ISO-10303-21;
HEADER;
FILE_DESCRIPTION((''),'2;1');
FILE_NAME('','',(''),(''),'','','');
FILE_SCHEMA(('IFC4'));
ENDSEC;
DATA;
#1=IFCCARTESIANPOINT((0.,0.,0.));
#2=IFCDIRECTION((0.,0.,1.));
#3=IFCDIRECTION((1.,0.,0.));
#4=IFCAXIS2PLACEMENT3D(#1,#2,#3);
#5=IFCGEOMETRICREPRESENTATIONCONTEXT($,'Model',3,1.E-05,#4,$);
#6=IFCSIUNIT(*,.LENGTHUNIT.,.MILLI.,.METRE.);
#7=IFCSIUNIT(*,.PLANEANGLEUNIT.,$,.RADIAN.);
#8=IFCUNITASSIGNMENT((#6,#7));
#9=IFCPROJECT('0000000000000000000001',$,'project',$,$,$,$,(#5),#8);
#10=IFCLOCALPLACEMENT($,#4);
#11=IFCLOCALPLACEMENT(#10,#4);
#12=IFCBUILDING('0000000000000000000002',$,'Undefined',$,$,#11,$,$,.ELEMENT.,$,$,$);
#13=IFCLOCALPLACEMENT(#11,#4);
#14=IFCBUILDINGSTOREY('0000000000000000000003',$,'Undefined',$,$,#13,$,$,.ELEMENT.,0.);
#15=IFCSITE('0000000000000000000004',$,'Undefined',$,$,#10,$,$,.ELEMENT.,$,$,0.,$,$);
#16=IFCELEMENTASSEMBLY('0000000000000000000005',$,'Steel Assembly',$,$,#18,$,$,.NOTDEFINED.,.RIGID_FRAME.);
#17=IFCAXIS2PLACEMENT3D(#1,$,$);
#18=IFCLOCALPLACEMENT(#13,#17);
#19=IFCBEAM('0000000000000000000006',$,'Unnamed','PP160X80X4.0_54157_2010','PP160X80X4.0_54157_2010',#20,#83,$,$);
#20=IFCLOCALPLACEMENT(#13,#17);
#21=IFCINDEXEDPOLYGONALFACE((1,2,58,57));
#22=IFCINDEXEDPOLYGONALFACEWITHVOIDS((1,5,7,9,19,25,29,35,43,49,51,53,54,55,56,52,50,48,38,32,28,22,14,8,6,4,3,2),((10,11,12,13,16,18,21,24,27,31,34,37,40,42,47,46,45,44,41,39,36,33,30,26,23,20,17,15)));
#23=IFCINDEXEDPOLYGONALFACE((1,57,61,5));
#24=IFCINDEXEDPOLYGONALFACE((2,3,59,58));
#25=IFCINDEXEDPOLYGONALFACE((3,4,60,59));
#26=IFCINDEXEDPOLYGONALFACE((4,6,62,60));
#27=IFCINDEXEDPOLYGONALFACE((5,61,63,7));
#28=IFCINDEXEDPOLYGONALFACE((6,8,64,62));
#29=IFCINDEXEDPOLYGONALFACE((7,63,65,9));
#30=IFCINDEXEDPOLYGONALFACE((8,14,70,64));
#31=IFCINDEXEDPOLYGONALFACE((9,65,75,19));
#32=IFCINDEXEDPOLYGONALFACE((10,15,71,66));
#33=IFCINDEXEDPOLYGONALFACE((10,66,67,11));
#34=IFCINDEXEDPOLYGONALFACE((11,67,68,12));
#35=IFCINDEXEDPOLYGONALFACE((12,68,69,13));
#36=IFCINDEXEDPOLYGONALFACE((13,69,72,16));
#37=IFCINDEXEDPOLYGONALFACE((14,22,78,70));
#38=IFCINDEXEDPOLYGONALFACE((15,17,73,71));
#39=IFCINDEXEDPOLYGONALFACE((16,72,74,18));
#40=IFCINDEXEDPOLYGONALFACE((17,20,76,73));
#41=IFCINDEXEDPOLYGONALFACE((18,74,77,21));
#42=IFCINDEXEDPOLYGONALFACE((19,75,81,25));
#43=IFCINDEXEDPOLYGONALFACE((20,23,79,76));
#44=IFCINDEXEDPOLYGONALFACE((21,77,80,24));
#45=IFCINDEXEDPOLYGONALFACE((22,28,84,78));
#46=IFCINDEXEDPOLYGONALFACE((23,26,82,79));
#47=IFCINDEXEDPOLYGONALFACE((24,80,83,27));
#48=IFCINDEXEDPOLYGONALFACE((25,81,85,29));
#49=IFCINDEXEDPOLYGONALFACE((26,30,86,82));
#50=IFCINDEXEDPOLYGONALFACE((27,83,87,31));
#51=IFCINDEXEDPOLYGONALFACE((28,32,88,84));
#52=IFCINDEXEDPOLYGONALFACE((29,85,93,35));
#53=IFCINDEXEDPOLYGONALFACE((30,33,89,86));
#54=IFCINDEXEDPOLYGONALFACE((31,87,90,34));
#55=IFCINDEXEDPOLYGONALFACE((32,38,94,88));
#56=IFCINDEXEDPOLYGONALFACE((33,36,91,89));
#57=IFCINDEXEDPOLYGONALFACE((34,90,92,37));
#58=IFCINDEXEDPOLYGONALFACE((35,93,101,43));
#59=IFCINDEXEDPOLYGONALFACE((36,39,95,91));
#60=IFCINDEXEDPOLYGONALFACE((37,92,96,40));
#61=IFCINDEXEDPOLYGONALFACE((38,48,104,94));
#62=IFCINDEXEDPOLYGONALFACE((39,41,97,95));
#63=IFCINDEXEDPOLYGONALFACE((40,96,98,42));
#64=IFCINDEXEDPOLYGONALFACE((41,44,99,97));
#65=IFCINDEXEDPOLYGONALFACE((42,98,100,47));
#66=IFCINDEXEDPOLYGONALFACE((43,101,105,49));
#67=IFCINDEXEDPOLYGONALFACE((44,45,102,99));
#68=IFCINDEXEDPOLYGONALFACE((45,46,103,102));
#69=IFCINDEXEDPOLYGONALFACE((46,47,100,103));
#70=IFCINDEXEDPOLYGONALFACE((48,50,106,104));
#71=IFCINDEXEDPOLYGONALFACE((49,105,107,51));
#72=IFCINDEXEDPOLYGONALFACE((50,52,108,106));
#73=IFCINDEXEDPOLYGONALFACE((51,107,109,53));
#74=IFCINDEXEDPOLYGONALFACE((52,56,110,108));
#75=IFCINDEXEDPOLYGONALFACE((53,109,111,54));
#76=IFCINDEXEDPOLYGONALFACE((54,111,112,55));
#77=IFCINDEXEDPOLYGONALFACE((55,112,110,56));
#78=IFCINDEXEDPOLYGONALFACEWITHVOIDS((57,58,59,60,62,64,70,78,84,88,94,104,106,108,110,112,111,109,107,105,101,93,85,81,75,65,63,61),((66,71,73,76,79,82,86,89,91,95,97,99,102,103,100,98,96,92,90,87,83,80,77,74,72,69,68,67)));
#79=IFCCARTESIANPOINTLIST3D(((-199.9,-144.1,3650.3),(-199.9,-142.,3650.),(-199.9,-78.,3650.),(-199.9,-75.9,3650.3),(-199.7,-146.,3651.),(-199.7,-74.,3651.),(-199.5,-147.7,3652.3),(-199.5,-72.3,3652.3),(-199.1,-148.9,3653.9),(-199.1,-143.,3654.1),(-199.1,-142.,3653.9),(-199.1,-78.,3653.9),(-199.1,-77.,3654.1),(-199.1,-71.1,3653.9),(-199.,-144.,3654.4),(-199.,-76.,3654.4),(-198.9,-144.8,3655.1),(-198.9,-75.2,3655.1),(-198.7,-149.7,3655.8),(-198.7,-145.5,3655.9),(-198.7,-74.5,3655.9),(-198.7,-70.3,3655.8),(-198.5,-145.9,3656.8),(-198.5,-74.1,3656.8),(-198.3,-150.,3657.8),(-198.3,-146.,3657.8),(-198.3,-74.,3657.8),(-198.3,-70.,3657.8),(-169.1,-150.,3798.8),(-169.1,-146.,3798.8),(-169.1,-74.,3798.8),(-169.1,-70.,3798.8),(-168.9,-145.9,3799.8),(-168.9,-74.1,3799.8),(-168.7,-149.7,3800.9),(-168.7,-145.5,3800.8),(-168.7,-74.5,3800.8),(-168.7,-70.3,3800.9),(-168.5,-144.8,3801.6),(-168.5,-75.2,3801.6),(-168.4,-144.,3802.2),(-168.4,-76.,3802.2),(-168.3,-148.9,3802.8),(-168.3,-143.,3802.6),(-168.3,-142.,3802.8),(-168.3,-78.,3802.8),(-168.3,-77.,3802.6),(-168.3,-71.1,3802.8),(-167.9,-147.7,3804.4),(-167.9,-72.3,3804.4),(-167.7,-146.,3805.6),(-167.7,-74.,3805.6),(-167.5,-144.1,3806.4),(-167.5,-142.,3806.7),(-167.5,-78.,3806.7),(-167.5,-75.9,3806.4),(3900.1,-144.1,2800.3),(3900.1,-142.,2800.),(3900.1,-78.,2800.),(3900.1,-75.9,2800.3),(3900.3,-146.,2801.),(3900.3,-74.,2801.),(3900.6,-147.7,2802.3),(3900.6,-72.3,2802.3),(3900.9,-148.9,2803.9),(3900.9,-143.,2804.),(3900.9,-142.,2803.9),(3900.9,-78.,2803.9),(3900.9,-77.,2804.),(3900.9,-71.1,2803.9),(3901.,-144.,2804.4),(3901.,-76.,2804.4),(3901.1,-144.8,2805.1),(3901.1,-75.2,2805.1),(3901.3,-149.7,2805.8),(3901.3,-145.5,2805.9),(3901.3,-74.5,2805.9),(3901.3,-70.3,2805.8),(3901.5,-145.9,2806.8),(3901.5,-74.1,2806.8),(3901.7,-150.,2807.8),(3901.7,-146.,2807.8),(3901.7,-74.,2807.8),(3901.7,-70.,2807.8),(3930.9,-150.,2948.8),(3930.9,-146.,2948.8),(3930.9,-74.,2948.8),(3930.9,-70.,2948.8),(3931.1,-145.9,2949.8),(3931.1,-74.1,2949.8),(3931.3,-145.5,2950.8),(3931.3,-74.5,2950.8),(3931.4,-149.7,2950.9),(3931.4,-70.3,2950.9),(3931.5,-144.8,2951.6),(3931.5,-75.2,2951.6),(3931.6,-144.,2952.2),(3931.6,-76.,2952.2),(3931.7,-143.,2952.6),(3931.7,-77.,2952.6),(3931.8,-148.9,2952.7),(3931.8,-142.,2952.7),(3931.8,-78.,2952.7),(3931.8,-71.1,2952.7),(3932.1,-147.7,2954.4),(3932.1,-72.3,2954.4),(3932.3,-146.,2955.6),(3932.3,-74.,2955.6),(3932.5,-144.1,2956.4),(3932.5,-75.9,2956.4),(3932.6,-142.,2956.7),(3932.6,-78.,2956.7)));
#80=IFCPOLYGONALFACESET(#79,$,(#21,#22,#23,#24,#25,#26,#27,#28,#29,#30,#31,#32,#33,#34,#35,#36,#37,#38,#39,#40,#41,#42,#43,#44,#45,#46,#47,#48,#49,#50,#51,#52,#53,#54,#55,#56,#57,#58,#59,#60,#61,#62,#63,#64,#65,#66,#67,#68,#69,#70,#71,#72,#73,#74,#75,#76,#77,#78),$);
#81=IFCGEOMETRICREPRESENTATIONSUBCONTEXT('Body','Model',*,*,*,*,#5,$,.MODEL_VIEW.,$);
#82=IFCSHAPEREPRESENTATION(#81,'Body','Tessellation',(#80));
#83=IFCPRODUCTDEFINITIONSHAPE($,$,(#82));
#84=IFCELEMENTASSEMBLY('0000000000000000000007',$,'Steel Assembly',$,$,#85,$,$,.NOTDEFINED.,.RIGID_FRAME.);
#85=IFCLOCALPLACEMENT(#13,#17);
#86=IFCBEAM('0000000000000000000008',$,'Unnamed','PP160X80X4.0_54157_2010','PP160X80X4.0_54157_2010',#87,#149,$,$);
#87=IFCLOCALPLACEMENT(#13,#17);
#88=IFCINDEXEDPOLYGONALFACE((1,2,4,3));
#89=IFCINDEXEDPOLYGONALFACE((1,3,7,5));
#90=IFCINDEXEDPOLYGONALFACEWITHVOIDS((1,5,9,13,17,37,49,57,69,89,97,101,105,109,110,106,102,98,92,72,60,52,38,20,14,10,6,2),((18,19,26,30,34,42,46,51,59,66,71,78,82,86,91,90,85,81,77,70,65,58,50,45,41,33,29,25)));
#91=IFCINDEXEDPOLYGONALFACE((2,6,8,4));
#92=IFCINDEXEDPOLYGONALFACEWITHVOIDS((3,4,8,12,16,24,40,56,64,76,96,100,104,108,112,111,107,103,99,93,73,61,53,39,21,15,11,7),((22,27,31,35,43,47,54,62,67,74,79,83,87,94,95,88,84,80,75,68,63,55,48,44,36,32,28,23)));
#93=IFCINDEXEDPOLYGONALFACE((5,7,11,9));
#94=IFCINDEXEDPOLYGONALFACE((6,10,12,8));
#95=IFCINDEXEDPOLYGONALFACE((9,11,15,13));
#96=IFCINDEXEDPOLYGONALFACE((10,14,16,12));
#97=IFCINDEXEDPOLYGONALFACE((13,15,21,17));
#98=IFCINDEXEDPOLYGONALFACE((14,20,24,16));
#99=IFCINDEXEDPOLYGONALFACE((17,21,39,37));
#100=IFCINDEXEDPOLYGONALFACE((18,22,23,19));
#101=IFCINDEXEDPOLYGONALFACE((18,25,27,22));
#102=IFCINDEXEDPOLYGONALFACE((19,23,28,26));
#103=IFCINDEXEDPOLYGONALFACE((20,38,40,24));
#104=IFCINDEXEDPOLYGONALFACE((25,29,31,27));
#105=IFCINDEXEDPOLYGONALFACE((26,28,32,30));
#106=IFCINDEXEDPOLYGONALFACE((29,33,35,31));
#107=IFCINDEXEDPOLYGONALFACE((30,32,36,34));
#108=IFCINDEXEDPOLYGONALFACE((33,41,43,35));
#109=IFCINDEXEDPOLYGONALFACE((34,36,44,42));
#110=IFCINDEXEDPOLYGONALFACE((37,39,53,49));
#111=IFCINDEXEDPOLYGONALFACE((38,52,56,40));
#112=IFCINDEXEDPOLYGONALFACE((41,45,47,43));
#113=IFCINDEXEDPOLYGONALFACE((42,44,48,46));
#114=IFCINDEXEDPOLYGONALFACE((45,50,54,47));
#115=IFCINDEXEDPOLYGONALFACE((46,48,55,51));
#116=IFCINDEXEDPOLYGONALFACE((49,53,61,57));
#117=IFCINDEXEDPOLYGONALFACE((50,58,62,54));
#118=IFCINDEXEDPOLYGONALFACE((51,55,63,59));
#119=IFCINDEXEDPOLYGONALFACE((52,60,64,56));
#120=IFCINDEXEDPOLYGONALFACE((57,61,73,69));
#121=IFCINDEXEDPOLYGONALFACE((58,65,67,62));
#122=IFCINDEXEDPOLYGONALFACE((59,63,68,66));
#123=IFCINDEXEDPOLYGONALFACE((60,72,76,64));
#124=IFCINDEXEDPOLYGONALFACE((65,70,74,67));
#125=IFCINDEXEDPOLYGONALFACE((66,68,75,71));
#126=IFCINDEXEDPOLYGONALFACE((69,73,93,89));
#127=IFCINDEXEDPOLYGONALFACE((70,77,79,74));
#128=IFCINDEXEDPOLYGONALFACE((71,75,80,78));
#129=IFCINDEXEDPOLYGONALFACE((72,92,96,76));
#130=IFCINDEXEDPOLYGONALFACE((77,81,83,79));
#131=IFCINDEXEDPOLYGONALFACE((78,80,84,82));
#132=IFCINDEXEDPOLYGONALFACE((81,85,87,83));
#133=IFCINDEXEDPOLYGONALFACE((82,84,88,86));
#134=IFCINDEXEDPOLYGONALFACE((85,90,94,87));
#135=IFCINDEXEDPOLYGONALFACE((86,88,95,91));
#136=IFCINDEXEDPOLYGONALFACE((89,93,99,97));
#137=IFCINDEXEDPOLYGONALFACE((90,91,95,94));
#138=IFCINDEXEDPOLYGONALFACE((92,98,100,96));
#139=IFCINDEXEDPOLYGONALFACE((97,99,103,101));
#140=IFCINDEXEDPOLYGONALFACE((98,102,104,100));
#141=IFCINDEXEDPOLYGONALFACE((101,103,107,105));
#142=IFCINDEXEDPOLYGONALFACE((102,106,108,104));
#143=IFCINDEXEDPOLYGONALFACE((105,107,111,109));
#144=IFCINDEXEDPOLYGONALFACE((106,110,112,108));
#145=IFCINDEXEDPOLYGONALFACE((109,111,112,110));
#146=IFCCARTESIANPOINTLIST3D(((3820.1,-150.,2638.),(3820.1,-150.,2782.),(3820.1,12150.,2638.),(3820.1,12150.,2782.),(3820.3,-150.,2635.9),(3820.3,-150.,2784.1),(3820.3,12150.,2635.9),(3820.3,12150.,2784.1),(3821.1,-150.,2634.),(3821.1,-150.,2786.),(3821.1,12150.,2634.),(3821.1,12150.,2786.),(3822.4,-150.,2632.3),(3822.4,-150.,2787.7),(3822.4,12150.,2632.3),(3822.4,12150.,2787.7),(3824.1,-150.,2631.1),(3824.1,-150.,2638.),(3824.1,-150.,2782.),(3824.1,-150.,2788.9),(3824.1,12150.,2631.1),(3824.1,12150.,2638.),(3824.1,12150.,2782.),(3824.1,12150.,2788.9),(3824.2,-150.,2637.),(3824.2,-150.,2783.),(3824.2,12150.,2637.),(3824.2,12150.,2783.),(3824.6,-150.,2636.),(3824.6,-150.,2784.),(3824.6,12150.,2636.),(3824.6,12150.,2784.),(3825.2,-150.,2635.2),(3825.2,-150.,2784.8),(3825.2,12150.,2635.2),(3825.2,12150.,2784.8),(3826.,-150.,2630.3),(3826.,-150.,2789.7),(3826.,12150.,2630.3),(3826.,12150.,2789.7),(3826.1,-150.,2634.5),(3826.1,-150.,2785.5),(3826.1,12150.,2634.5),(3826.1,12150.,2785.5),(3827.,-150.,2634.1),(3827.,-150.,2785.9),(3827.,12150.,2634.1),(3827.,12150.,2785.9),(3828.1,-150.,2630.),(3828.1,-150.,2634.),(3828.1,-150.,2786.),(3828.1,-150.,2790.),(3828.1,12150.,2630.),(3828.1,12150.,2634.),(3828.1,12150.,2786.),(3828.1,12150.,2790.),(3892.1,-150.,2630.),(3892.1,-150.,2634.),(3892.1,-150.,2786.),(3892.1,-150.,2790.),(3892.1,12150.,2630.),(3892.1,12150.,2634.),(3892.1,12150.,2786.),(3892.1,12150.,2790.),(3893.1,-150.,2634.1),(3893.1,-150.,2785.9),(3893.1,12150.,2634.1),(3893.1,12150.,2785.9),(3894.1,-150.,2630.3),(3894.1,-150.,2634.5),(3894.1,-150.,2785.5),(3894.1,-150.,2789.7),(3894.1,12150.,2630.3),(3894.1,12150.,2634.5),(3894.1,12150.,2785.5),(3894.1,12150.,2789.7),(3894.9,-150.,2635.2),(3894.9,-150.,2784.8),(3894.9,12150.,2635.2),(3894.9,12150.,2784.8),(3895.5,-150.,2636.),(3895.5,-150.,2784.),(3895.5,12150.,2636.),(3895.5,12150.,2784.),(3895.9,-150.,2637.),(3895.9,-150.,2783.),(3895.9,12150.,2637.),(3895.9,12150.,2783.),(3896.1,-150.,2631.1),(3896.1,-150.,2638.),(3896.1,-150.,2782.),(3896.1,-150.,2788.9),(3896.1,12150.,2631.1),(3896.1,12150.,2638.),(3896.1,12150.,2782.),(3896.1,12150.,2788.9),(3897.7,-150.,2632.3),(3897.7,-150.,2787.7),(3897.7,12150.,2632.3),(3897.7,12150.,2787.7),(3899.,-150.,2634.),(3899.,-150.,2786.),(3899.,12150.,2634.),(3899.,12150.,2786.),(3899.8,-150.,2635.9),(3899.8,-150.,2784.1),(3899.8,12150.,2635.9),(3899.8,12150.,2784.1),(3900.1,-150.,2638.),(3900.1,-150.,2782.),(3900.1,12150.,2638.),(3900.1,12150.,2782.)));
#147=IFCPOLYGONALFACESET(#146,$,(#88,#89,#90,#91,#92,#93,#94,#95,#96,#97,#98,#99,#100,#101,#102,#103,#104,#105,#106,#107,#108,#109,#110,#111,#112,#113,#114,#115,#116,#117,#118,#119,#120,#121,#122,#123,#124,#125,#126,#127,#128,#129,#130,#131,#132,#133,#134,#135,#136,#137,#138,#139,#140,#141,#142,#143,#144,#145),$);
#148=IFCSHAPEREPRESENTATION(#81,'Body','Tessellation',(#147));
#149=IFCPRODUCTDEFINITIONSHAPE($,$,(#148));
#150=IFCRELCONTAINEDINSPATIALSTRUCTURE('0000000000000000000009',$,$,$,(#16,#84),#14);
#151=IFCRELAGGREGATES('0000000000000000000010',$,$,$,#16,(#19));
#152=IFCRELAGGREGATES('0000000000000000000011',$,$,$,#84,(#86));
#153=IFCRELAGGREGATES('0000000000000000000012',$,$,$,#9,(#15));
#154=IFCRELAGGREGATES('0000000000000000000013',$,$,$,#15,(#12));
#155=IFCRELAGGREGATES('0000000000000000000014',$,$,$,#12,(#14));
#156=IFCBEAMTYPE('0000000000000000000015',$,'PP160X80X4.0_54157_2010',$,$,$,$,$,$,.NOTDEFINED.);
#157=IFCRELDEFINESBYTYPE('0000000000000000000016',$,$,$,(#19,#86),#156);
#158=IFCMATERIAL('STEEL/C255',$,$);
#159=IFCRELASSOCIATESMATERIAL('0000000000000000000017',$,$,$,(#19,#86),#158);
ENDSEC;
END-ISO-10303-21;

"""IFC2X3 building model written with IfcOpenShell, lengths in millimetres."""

from ifc_helpers import new_model, si_unit, frame, origin_with_axes, origin_2d_with_axis, place, context, subcontext, project, spatial, hollow_rectangle, extrude, material, type_object, element, aggregate, save


model = new_model("IFC2X3")

# Units and contexts
model_context = context("Model", 3, precision=1e-05, world=origin_with_axes())
body_context = subcontext(model_context, "Body", "Model", "MODEL_VIEW")
ifc_project = project(units=[si_unit("LENGTHUNIT", "METRE", prefix="MILLI"), si_unit("PLANEANGLEUNIT", "RADIAN")], contexts=[model_context])

# Site, building, storey
site_placement = place(None, origin_with_axes())
site = spatial("IfcSite", under=ifc_project, at=site_placement, Name="Undefined", CompositionType="ELEMENT", RefElevation=0.0)
building_placement = place(site_placement, origin_with_axes())
building = spatial("IfcBuilding", under=site, at=building_placement, Name="Undefined", CompositionType="ELEMENT")
storey_placement = place(building_placement, origin_with_axes())
storey = spatial("IfcBuildingStorey", under=building, at=storey_placement, Name="Undefined", CompositionType="ELEMENT", Elevation=0.0)

# Element assemblies, beams
ifc_material_1 = material(Name="STEEL/C255")
beam_type_1 = type_object("IfcBeamType", Name="PP160X80X4.0_54157_2010", PredefinedType="NOTDEFINED")
assembly_1_placement = place(storey_placement, origin_with_axes())
assembly_1 = element("IfcElementAssembly", 1, at=assembly_1_placement, inside=storey, Name="Steel Assembly", AssemblyPlace="NOTDEFINED", PredefinedType="RIGID_FRAME")
beam_1_placement = place(assembly_1_placement, frame((3916.3, -110.0, 2878.3), z_axis=(0.203, 0.0, 0.979179), x_axis=(-0.979179, 0.0, 0.203)))
beam_1 = element("IfcBeam", 2, at=beam_1_placement, type_object=beam_type_1, material=ifc_material_1, Name="Unnamed", Description="PP160X80X4.0_54157_2010", ObjectType="PP160X80X4.0_54157_2010", context=body_context, shape_type="SweptSolid", body=[
    extrude(hollow_rectangle(XDim=80.0, YDim=160.0, WallThickness=4.0, InnerFilletRadius=4.0, OuterFilletRadius=8.0, at=origin_2d_with_axis()), frame((4187.2, 0.0, 0.0), z_axis=(-1.0, 0.0, 0.0), x_axis=(0.0, -1.0, 0.0)), (0.0, 0.0, 1.0), 4187.2),
])
aggregate(assembly_1, [beam_1])
assembly_2_placement = place(storey_placement, origin_with_axes())
assembly_2 = element("IfcElementAssembly", 3, at=assembly_2_placement, inside=storey, Name="Steel Assembly", AssemblyPlace="NOTDEFINED", PredefinedType="RIGID_FRAME")
beam_2_placement = place(assembly_2_placement, frame((3860.1, -150.0, 2710.0), z_axis=(0.0, 0.0, 1.0), x_axis=(0.0, 1.0, 0.0)))
beam_2 = element("IfcBeam", 4, at=beam_2_placement, type_object=beam_type_1, material=ifc_material_1, Name="Unnamed", Description="PP160X80X4.0_54157_2010", ObjectType="PP160X80X4.0_54157_2010", context=body_context, shape_type="SweptSolid", body=[
    extrude(hollow_rectangle(XDim=80.0, YDim=160.0, WallThickness=4.0, InnerFilletRadius=4.0, OuterFilletRadius=8.0, at=origin_2d_with_axis()), frame((12300.0, 0.0, 0.0), z_axis=(-1.0, 0.0, 0.0), x_axis=(0.0, -1.0, 0.0)), (0.0, 0.0, 1.0), 12300.0),
])
aggregate(assembly_2, [beam_2])

save(model, "model.ifc")
